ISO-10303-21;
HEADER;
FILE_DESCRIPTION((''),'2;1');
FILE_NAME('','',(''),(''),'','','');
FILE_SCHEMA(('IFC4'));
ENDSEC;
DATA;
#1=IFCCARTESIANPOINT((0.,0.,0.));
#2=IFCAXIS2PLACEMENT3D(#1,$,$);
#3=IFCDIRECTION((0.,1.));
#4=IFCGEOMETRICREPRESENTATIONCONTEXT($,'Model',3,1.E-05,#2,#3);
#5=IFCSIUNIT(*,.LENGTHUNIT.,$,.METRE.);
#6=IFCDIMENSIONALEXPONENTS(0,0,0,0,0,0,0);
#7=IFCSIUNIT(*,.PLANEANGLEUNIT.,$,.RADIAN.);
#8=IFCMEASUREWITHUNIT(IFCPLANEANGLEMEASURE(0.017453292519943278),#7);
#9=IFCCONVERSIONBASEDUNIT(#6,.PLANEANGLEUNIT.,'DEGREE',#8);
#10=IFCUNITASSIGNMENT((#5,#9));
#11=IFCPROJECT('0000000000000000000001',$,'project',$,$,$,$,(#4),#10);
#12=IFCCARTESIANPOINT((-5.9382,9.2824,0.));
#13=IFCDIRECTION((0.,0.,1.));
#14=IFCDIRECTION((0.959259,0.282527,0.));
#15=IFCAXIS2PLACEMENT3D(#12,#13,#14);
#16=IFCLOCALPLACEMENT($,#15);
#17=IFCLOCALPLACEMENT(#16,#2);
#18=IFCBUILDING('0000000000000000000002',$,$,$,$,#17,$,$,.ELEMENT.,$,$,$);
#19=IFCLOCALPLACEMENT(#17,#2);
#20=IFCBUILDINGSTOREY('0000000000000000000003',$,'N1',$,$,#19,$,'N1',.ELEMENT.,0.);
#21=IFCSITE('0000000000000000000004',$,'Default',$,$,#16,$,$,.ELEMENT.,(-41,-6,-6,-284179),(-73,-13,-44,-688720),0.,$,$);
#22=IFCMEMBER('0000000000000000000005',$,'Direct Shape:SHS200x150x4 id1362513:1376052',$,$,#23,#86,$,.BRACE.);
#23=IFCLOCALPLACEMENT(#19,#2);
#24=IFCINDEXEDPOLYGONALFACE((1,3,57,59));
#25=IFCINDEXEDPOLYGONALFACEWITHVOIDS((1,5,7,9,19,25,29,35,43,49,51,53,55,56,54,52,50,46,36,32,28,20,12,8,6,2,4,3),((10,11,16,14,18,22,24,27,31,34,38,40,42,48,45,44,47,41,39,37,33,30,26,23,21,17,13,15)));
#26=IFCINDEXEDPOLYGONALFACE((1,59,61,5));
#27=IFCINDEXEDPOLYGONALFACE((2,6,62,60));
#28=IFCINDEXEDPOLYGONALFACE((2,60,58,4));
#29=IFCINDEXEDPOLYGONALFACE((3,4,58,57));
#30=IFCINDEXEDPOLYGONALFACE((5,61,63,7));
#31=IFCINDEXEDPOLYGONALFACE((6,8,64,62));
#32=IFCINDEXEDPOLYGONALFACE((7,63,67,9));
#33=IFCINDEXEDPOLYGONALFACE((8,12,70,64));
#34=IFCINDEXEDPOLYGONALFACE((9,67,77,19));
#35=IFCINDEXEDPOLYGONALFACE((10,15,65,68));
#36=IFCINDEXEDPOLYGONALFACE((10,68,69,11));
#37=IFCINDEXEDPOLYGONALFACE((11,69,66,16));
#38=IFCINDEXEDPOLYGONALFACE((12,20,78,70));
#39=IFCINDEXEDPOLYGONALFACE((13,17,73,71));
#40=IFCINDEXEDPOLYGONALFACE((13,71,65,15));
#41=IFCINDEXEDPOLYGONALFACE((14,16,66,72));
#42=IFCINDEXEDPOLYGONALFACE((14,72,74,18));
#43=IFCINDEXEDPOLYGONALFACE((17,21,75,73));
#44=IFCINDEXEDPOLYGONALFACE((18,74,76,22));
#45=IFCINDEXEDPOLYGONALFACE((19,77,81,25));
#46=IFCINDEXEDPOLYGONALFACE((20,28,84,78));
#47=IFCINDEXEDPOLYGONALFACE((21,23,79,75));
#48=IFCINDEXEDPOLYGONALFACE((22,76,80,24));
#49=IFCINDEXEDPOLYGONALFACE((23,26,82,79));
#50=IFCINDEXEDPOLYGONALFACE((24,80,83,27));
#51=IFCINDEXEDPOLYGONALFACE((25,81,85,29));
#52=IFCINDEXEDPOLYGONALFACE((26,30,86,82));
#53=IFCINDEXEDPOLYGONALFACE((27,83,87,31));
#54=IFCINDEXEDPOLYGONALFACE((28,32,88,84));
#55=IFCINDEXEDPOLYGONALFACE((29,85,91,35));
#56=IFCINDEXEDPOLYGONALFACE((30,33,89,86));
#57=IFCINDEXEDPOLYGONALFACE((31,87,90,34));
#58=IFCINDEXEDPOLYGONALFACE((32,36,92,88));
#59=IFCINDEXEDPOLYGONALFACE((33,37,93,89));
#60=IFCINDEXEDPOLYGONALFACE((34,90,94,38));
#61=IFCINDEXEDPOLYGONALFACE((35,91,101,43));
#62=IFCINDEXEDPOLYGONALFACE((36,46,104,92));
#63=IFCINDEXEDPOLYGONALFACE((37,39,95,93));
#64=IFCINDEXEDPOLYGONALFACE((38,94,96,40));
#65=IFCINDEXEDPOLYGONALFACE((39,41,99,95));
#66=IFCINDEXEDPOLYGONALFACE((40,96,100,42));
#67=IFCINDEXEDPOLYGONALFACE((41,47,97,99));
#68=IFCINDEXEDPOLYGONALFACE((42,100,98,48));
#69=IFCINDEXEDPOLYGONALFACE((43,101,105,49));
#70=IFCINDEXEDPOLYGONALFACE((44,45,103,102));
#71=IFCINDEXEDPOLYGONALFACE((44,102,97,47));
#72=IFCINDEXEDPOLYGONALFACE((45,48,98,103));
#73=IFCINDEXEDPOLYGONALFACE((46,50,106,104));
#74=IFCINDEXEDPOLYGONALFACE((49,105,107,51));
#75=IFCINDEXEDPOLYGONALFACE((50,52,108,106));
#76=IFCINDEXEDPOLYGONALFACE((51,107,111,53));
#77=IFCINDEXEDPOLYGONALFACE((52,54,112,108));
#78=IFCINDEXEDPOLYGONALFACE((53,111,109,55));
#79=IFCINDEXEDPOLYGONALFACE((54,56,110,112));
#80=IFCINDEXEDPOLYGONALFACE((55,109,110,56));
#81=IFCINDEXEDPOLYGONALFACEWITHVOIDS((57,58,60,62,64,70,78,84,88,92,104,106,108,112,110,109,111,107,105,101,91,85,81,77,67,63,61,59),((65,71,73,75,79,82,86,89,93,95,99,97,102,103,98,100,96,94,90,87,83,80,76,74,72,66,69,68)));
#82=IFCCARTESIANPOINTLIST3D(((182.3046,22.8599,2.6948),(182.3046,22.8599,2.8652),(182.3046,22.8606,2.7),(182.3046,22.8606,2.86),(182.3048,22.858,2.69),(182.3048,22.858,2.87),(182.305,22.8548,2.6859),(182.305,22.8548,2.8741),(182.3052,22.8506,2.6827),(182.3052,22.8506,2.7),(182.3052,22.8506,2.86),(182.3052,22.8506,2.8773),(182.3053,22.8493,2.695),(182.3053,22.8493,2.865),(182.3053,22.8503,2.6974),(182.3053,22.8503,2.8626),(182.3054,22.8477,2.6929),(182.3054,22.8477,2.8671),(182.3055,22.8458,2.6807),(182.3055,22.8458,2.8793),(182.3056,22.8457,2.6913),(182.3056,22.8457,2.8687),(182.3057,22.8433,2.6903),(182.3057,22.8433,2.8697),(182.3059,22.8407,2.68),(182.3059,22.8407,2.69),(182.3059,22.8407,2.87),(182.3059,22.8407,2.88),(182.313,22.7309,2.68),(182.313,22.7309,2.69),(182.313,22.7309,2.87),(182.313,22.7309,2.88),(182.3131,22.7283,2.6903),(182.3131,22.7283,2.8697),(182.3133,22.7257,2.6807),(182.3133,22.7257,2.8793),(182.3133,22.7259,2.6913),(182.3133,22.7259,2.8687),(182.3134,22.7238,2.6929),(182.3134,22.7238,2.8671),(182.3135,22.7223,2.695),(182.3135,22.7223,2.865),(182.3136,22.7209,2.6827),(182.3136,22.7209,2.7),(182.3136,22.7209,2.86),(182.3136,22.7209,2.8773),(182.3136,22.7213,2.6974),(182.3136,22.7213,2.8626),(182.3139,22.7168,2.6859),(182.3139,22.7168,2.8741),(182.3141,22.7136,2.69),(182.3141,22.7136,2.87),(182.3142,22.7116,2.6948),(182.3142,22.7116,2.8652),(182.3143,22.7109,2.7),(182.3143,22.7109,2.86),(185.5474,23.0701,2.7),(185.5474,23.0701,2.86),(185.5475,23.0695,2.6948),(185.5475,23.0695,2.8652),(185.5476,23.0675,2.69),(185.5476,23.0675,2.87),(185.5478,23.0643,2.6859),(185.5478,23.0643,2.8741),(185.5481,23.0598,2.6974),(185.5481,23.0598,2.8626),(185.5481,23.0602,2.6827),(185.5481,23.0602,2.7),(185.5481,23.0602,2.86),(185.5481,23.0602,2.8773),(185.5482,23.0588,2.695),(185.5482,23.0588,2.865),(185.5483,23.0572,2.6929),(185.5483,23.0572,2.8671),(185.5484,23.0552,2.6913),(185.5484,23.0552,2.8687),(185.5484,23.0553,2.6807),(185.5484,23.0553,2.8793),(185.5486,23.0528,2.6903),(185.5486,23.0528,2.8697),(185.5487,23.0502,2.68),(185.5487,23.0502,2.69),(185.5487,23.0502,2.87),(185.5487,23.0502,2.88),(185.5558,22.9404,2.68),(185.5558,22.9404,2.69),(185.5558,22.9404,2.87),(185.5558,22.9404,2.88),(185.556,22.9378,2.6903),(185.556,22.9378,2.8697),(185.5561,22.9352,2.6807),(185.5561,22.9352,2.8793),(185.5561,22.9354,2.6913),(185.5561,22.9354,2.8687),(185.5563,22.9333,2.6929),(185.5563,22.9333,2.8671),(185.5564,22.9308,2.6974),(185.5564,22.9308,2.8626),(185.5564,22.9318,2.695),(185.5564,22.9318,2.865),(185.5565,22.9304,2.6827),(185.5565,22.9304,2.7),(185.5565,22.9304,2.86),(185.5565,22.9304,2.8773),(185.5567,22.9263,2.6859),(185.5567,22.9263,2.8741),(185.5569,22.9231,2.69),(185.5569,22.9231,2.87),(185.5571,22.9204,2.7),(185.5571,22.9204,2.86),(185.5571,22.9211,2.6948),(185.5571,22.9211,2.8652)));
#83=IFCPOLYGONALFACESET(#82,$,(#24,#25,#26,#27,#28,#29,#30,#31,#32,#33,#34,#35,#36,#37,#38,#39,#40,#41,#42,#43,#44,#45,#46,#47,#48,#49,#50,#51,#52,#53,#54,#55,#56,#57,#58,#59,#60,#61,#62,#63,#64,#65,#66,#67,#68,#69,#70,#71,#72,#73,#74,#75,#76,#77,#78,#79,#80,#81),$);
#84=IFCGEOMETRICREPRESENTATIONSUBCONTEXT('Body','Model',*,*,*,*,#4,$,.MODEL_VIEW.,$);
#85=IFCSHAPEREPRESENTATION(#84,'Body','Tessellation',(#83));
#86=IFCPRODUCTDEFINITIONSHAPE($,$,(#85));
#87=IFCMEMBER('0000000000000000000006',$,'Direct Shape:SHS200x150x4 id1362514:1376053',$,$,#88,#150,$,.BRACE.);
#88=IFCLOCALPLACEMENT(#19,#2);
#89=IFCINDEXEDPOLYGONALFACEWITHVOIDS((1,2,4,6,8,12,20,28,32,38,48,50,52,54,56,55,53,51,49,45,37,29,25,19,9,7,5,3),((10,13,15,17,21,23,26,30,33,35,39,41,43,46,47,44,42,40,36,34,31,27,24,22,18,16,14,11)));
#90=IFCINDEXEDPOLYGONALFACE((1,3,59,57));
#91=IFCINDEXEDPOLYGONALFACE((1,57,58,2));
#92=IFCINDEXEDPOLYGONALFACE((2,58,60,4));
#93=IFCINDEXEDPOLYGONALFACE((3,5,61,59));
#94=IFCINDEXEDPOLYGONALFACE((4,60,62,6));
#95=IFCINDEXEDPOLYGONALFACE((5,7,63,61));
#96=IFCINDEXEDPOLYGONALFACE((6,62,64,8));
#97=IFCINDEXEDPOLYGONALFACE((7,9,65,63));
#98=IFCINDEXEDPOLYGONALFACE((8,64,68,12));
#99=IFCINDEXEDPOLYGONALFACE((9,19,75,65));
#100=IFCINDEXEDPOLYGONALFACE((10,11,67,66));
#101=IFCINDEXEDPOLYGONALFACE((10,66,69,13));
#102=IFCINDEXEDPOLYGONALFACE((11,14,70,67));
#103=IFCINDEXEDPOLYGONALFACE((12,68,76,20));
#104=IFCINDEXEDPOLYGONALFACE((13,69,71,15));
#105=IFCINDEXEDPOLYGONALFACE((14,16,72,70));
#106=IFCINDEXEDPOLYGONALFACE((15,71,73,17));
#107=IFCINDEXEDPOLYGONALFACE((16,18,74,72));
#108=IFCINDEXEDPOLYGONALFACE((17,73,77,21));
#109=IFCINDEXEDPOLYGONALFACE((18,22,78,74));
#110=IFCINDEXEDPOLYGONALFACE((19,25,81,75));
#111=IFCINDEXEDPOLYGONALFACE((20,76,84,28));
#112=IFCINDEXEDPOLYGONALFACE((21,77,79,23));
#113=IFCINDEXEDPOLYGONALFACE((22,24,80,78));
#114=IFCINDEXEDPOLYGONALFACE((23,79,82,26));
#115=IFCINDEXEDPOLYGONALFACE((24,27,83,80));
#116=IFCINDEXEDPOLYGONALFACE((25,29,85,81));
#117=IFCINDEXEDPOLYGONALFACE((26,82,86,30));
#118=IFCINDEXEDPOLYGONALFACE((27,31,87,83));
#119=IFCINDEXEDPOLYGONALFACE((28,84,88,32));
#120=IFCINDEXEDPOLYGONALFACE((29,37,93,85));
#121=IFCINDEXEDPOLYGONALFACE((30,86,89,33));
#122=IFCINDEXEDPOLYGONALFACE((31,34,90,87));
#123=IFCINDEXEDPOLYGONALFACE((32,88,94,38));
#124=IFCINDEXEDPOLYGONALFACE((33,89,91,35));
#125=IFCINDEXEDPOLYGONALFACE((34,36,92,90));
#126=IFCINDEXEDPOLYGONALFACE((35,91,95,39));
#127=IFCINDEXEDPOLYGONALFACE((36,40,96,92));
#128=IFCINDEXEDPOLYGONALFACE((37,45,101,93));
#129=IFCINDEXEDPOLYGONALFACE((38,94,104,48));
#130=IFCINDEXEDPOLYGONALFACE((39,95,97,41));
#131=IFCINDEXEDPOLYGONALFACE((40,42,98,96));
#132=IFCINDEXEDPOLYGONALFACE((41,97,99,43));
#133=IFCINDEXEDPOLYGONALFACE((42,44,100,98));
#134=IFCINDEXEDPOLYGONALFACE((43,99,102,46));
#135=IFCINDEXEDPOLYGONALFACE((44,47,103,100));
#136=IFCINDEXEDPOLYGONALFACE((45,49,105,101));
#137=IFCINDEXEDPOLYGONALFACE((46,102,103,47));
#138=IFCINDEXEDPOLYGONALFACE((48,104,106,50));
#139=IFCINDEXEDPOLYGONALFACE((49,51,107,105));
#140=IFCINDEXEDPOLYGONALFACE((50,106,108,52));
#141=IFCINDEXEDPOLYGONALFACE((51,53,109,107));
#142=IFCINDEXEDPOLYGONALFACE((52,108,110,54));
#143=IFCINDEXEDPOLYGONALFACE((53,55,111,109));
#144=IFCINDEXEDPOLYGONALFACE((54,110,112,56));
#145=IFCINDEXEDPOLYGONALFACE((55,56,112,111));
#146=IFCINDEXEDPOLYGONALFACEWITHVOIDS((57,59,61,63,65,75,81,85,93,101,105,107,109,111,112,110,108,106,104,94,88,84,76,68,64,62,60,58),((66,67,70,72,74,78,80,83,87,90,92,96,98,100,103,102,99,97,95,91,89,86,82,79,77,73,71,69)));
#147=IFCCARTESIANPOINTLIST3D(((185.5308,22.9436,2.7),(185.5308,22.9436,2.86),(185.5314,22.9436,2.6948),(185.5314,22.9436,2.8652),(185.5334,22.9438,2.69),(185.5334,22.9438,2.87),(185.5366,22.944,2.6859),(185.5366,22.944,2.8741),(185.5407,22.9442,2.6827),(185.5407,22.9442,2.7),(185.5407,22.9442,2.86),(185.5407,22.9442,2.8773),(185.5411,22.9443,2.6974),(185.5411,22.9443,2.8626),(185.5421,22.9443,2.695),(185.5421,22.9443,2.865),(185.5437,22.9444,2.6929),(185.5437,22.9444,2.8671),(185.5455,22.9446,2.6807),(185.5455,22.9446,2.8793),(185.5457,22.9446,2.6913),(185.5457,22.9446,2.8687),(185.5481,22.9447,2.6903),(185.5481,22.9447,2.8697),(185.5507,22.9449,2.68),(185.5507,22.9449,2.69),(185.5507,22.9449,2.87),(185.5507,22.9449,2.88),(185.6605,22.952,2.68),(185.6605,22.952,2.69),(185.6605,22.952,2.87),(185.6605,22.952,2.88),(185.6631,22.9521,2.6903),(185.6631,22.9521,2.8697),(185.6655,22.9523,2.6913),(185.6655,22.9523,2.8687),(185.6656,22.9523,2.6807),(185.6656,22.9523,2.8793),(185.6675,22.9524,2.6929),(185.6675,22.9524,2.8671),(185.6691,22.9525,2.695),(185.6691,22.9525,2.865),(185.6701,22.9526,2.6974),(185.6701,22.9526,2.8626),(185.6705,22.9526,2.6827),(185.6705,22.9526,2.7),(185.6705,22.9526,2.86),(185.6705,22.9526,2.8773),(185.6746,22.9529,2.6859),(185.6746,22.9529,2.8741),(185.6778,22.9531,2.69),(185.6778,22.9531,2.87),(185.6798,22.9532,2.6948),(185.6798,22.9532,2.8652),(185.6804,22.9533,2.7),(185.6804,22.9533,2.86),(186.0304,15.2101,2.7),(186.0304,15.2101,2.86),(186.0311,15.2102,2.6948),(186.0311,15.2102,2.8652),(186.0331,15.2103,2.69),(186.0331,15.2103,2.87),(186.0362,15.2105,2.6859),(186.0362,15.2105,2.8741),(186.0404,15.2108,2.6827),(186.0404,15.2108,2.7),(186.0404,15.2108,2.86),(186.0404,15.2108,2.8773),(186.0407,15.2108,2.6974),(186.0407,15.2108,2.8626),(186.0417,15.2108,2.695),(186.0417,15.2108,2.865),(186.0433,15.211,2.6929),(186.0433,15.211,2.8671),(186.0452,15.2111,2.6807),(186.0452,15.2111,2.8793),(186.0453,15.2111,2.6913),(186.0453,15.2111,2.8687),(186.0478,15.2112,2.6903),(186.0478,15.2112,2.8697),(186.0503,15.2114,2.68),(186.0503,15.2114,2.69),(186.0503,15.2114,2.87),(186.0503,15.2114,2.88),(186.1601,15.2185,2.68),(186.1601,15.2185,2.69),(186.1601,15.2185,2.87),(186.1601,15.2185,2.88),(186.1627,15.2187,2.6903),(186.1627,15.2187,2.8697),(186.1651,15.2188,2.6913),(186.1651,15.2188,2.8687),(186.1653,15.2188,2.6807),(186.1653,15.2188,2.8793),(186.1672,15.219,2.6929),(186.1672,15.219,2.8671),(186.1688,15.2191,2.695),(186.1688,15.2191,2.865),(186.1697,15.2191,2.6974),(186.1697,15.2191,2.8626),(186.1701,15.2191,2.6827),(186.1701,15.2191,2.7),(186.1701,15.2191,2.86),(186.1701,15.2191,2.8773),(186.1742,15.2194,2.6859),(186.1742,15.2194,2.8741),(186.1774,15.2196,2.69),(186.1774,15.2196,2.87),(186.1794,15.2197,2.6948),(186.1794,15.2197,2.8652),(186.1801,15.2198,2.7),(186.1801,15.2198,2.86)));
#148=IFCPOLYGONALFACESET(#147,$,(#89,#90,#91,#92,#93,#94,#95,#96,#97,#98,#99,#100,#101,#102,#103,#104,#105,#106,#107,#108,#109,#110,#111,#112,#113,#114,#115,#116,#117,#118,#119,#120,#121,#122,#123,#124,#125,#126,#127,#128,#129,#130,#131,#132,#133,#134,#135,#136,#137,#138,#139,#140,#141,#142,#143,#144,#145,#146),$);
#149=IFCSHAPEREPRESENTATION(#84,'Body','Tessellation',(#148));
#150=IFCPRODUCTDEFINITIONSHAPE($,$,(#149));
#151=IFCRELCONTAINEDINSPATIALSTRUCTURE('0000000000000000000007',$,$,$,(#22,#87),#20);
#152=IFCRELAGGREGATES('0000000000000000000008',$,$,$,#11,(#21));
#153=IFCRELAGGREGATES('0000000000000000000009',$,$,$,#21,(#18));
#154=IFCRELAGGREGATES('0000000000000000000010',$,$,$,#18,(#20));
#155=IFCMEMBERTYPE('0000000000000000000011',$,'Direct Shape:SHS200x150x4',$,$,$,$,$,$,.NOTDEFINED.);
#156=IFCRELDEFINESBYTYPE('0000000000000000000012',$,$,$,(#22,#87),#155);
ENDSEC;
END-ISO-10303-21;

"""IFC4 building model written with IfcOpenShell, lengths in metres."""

from ifc_helpers import new_model, entity, si_unit, converted_unit, direction, frame, frame_2d, origin, place, context, subcontext, project, spatial, polyline, circle_curve, parameter, trimmed, segment, composite_curve, outline, extrude, type_object, element, save


model = new_model("IFC4")

# Units and contexts
model_context = context("Model", 3, precision=1e-05, world=origin(), true_north=direction((0.0, 1.0)))
body_context = subcontext(model_context, "Body", "Model", "MODEL_VIEW")
ifc_project = project(units=[si_unit("LENGTHUNIT", "METRE"), converted_unit("PLANEANGLEUNIT", "DEGREE", entity("IfcPlaneAngleMeasure", 0.017453292519943278), si_unit("PLANEANGLEUNIT", "RADIAN"), dimensions=[0, 0, 0, 0, 0, 0, 0])], contexts=[model_context])

# Site, building, storey
site_placement = place(None, frame((-5.9382, 9.2824, 0.0), z_axis=(0.0, 0.0, 1.0), x_axis=(0.959259, 0.282527, 0.0)))
site = spatial("IfcSite", under=ifc_project, at=site_placement, Name="Default", CompositionType="ELEMENT", RefLatitude=(-41, -6, -6, -284179), RefLongitude=(-73, -13, -44, -688720), RefElevation=0.0)
building_placement = place(site_placement, origin())
building = spatial("IfcBuilding", under=site, at=building_placement, CompositionType="ELEMENT")
storey_placement = place(building_placement, origin())
storey = spatial("IfcBuildingStorey", under=building, at=storey_placement, Name="N1", LongName="N1", CompositionType="ELEMENT", Elevation=0.0)

# Members
member_type_1 = type_object("IfcMemberType", Name="Direct Shape:SHS200x150x4", PredefinedType="NOTDEFINED")
member_1_placement = place(storey_placement, origin())
element("IfcMember", 1, at=member_1_placement, inside=storey, type_object=member_type_1, Name="Direct Shape:SHS200x150x4 id1362513:1376052", PredefinedType="BRACE", context=body_context, shape_type="SweptSolid", body=[
    extrude(outline(composite_curve([segment(polyline([(-0.08, -0.075), (0.08, -0.075)]), True, "CONTINUOUS"), segment(trimmed(circle_curve(frame_2d((0.08, -0.055), x_axis=(0.0, 1.0)), 0.02), [parameter(180.0)], [parameter(270.0)], True, "PARAMETER"), True, "CONTINUOUS"), segment(polyline([(0.1, -0.055), (0.1, 0.055)]), True, "CONTINUOUS"), segment(trimmed(circle_curve(frame_2d((0.08, 0.055), x_axis=(0.0, 1.0)), 0.02), [parameter(270.0)], [parameter(0.0)], True, "PARAMETER"), True, "CONTINUOUS"), segment(polyline([(0.08, 0.075), (-0.08, 0.075)]), True, "CONTINUOUS"), segment(trimmed(circle_curve(frame_2d((-0.08, 0.055), x_axis=(0.0, 1.0)), 0.02), [parameter(360.0)], [parameter(90.0)], True, "PARAMETER"), True, "CONTINUOUS"), segment(polyline([(-0.1, 0.055), (-0.1, -0.055)]), True, "CONTINUOUS"), segment(trimmed(circle_curve(frame_2d((-0.08, -0.055), x_axis=(0.0, 1.0)), 0.02), [parameter(90.0)], [parameter(180.0)], True, "PARAMETER"), True, "CONTINUOUS")], self_intersect=False), holes=[composite_curve([segment(trimmed(circle_curve(frame_2d((-0.08, 0.055), x_axis=(0.0, 1.0)), 0.01), [parameter(360.0)], [parameter(90.0)], True, "PARAMETER"), False, "CONTINUOUS"), segment(polyline([(-0.08, 0.065), (0.08, 0.065)]), True, "CONTINUOUS"), segment(trimmed(circle_curve(frame_2d((0.08, 0.055), x_axis=(0.0, 1.0)), 0.01), [parameter(270.0)], [parameter(0.0)], True, "PARAMETER"), False, "CONTINUOUS"), segment(polyline([(0.09, 0.055), (0.09, -0.055)]), True, "CONTINUOUS"), segment(trimmed(circle_curve(frame_2d((0.08, -0.055), x_axis=(0.0, 1.0)), 0.01), [parameter(180.0)], [parameter(270.0)], True, "PARAMETER"), False, "CONTINUOUS"), segment(polyline([(0.08, -0.065), (-0.08, -0.065)]), True, "CONTINUOUS"), segment(trimmed(circle_curve(frame_2d((-0.08, -0.055), x_axis=(0.0, 1.0)), 0.01), [parameter(90.0)], [parameter(180.0)], True, "PARAMETER"), False, "CONTINUOUS"), segment(polyline([(-0.09, -0.055), (-0.09, 0.055)]), True, "CONTINUOUS")], self_intersect=False)]), frame((182.3094, 22.7858, 2.78), z_axis=(0.99792, 0.064471, 0.0), x_axis=(0.0, 0.0, -1.0)), (0.0, 0.0, 1.0), 3.2496),
])
member_2_placement = place(storey_placement, origin())
element("IfcMember", 2, at=member_2_placement, inside=storey, type_object=member_type_1, Name="Direct Shape:SHS200x150x4 id1362514:1376053", PredefinedType="BRACE", context=body_context, shape_type="SweptSolid", body=[
    extrude(outline(composite_curve([segment(polyline([(-0.08, -0.075), (0.08, -0.075)]), True, "CONTINUOUS"), segment(trimmed(circle_curve(frame_2d((0.08, -0.055), x_axis=(0.0, 1.0)), 0.02), [parameter(180.0)], [parameter(270.0)], True, "PARAMETER"), True, "CONTINUOUS"), segment(polyline([(0.1, -0.055), (0.1, 0.055)]), True, "CONTINUOUS"), segment(trimmed(circle_curve(frame_2d((0.08, 0.055), x_axis=(0.0, 1.0)), 0.02), [parameter(270.0)], [parameter(0.0)], True, "PARAMETER"), True, "CONTINUOUS"), segment(polyline([(0.08, 0.075), (-0.08, 0.075)]), True, "CONTINUOUS"), segment(trimmed(circle_curve(frame_2d((-0.08, 0.055), x_axis=(0.0, 1.0)), 0.02), [parameter(360.0)], [parameter(90.0)], True, "PARAMETER"), True, "CONTINUOUS"), segment(polyline([(-0.1, 0.055), (-0.1, -0.055)]), True, "CONTINUOUS"), segment(trimmed(circle_curve(frame_2d((-0.08, -0.055), x_axis=(0.0, 1.0)), 0.02), [parameter(90.0)], [parameter(180.0)], True, "PARAMETER"), True, "CONTINUOUS")], self_intersect=False), holes=[composite_curve([segment(trimmed(circle_curve(frame_2d((-0.08, 0.055), x_axis=(0.0, 1.0)), 0.01), [parameter(360.0)], [parameter(90.0)], True, "PARAMETER"), False, "CONTINUOUS"), segment(polyline([(-0.08, 0.065), (0.08, 0.065)]), True, "CONTINUOUS"), segment(trimmed(circle_curve(frame_2d((0.08, 0.055), x_axis=(0.0, 1.0)), 0.01), [parameter(270.0)], [parameter(0.0)], True, "PARAMETER"), False, "CONTINUOUS"), segment(polyline([(0.09, 0.055), (0.09, -0.055)]), True, "CONTINUOUS"), segment(trimmed(circle_curve(frame_2d((0.08, -0.055), x_axis=(0.0, 1.0)), 0.01), [parameter(180.0)], [parameter(270.0)], True, "PARAMETER"), False, "CONTINUOUS"), segment(polyline([(0.08, -0.065), (-0.08, -0.065)]), True, "CONTINUOUS"), segment(trimmed(circle_curve(frame_2d((-0.08, -0.055), x_axis=(0.0, 1.0)), 0.01), [parameter(90.0)], [parameter(180.0)], True, "PARAMETER"), False, "CONTINUOUS"), segment(polyline([(-0.09, -0.055), (-0.09, 0.055)]), True, "CONTINUOUS")], self_intersect=False)]), frame((186.1052, 15.215, 2.78), z_axis=(-0.064471, 0.99792, 0.0), x_axis=(0.0, 0.0, -1.0)), (0.0, 0.0, 1.0), 7.7496),
])

save(model, "model.ifc")
